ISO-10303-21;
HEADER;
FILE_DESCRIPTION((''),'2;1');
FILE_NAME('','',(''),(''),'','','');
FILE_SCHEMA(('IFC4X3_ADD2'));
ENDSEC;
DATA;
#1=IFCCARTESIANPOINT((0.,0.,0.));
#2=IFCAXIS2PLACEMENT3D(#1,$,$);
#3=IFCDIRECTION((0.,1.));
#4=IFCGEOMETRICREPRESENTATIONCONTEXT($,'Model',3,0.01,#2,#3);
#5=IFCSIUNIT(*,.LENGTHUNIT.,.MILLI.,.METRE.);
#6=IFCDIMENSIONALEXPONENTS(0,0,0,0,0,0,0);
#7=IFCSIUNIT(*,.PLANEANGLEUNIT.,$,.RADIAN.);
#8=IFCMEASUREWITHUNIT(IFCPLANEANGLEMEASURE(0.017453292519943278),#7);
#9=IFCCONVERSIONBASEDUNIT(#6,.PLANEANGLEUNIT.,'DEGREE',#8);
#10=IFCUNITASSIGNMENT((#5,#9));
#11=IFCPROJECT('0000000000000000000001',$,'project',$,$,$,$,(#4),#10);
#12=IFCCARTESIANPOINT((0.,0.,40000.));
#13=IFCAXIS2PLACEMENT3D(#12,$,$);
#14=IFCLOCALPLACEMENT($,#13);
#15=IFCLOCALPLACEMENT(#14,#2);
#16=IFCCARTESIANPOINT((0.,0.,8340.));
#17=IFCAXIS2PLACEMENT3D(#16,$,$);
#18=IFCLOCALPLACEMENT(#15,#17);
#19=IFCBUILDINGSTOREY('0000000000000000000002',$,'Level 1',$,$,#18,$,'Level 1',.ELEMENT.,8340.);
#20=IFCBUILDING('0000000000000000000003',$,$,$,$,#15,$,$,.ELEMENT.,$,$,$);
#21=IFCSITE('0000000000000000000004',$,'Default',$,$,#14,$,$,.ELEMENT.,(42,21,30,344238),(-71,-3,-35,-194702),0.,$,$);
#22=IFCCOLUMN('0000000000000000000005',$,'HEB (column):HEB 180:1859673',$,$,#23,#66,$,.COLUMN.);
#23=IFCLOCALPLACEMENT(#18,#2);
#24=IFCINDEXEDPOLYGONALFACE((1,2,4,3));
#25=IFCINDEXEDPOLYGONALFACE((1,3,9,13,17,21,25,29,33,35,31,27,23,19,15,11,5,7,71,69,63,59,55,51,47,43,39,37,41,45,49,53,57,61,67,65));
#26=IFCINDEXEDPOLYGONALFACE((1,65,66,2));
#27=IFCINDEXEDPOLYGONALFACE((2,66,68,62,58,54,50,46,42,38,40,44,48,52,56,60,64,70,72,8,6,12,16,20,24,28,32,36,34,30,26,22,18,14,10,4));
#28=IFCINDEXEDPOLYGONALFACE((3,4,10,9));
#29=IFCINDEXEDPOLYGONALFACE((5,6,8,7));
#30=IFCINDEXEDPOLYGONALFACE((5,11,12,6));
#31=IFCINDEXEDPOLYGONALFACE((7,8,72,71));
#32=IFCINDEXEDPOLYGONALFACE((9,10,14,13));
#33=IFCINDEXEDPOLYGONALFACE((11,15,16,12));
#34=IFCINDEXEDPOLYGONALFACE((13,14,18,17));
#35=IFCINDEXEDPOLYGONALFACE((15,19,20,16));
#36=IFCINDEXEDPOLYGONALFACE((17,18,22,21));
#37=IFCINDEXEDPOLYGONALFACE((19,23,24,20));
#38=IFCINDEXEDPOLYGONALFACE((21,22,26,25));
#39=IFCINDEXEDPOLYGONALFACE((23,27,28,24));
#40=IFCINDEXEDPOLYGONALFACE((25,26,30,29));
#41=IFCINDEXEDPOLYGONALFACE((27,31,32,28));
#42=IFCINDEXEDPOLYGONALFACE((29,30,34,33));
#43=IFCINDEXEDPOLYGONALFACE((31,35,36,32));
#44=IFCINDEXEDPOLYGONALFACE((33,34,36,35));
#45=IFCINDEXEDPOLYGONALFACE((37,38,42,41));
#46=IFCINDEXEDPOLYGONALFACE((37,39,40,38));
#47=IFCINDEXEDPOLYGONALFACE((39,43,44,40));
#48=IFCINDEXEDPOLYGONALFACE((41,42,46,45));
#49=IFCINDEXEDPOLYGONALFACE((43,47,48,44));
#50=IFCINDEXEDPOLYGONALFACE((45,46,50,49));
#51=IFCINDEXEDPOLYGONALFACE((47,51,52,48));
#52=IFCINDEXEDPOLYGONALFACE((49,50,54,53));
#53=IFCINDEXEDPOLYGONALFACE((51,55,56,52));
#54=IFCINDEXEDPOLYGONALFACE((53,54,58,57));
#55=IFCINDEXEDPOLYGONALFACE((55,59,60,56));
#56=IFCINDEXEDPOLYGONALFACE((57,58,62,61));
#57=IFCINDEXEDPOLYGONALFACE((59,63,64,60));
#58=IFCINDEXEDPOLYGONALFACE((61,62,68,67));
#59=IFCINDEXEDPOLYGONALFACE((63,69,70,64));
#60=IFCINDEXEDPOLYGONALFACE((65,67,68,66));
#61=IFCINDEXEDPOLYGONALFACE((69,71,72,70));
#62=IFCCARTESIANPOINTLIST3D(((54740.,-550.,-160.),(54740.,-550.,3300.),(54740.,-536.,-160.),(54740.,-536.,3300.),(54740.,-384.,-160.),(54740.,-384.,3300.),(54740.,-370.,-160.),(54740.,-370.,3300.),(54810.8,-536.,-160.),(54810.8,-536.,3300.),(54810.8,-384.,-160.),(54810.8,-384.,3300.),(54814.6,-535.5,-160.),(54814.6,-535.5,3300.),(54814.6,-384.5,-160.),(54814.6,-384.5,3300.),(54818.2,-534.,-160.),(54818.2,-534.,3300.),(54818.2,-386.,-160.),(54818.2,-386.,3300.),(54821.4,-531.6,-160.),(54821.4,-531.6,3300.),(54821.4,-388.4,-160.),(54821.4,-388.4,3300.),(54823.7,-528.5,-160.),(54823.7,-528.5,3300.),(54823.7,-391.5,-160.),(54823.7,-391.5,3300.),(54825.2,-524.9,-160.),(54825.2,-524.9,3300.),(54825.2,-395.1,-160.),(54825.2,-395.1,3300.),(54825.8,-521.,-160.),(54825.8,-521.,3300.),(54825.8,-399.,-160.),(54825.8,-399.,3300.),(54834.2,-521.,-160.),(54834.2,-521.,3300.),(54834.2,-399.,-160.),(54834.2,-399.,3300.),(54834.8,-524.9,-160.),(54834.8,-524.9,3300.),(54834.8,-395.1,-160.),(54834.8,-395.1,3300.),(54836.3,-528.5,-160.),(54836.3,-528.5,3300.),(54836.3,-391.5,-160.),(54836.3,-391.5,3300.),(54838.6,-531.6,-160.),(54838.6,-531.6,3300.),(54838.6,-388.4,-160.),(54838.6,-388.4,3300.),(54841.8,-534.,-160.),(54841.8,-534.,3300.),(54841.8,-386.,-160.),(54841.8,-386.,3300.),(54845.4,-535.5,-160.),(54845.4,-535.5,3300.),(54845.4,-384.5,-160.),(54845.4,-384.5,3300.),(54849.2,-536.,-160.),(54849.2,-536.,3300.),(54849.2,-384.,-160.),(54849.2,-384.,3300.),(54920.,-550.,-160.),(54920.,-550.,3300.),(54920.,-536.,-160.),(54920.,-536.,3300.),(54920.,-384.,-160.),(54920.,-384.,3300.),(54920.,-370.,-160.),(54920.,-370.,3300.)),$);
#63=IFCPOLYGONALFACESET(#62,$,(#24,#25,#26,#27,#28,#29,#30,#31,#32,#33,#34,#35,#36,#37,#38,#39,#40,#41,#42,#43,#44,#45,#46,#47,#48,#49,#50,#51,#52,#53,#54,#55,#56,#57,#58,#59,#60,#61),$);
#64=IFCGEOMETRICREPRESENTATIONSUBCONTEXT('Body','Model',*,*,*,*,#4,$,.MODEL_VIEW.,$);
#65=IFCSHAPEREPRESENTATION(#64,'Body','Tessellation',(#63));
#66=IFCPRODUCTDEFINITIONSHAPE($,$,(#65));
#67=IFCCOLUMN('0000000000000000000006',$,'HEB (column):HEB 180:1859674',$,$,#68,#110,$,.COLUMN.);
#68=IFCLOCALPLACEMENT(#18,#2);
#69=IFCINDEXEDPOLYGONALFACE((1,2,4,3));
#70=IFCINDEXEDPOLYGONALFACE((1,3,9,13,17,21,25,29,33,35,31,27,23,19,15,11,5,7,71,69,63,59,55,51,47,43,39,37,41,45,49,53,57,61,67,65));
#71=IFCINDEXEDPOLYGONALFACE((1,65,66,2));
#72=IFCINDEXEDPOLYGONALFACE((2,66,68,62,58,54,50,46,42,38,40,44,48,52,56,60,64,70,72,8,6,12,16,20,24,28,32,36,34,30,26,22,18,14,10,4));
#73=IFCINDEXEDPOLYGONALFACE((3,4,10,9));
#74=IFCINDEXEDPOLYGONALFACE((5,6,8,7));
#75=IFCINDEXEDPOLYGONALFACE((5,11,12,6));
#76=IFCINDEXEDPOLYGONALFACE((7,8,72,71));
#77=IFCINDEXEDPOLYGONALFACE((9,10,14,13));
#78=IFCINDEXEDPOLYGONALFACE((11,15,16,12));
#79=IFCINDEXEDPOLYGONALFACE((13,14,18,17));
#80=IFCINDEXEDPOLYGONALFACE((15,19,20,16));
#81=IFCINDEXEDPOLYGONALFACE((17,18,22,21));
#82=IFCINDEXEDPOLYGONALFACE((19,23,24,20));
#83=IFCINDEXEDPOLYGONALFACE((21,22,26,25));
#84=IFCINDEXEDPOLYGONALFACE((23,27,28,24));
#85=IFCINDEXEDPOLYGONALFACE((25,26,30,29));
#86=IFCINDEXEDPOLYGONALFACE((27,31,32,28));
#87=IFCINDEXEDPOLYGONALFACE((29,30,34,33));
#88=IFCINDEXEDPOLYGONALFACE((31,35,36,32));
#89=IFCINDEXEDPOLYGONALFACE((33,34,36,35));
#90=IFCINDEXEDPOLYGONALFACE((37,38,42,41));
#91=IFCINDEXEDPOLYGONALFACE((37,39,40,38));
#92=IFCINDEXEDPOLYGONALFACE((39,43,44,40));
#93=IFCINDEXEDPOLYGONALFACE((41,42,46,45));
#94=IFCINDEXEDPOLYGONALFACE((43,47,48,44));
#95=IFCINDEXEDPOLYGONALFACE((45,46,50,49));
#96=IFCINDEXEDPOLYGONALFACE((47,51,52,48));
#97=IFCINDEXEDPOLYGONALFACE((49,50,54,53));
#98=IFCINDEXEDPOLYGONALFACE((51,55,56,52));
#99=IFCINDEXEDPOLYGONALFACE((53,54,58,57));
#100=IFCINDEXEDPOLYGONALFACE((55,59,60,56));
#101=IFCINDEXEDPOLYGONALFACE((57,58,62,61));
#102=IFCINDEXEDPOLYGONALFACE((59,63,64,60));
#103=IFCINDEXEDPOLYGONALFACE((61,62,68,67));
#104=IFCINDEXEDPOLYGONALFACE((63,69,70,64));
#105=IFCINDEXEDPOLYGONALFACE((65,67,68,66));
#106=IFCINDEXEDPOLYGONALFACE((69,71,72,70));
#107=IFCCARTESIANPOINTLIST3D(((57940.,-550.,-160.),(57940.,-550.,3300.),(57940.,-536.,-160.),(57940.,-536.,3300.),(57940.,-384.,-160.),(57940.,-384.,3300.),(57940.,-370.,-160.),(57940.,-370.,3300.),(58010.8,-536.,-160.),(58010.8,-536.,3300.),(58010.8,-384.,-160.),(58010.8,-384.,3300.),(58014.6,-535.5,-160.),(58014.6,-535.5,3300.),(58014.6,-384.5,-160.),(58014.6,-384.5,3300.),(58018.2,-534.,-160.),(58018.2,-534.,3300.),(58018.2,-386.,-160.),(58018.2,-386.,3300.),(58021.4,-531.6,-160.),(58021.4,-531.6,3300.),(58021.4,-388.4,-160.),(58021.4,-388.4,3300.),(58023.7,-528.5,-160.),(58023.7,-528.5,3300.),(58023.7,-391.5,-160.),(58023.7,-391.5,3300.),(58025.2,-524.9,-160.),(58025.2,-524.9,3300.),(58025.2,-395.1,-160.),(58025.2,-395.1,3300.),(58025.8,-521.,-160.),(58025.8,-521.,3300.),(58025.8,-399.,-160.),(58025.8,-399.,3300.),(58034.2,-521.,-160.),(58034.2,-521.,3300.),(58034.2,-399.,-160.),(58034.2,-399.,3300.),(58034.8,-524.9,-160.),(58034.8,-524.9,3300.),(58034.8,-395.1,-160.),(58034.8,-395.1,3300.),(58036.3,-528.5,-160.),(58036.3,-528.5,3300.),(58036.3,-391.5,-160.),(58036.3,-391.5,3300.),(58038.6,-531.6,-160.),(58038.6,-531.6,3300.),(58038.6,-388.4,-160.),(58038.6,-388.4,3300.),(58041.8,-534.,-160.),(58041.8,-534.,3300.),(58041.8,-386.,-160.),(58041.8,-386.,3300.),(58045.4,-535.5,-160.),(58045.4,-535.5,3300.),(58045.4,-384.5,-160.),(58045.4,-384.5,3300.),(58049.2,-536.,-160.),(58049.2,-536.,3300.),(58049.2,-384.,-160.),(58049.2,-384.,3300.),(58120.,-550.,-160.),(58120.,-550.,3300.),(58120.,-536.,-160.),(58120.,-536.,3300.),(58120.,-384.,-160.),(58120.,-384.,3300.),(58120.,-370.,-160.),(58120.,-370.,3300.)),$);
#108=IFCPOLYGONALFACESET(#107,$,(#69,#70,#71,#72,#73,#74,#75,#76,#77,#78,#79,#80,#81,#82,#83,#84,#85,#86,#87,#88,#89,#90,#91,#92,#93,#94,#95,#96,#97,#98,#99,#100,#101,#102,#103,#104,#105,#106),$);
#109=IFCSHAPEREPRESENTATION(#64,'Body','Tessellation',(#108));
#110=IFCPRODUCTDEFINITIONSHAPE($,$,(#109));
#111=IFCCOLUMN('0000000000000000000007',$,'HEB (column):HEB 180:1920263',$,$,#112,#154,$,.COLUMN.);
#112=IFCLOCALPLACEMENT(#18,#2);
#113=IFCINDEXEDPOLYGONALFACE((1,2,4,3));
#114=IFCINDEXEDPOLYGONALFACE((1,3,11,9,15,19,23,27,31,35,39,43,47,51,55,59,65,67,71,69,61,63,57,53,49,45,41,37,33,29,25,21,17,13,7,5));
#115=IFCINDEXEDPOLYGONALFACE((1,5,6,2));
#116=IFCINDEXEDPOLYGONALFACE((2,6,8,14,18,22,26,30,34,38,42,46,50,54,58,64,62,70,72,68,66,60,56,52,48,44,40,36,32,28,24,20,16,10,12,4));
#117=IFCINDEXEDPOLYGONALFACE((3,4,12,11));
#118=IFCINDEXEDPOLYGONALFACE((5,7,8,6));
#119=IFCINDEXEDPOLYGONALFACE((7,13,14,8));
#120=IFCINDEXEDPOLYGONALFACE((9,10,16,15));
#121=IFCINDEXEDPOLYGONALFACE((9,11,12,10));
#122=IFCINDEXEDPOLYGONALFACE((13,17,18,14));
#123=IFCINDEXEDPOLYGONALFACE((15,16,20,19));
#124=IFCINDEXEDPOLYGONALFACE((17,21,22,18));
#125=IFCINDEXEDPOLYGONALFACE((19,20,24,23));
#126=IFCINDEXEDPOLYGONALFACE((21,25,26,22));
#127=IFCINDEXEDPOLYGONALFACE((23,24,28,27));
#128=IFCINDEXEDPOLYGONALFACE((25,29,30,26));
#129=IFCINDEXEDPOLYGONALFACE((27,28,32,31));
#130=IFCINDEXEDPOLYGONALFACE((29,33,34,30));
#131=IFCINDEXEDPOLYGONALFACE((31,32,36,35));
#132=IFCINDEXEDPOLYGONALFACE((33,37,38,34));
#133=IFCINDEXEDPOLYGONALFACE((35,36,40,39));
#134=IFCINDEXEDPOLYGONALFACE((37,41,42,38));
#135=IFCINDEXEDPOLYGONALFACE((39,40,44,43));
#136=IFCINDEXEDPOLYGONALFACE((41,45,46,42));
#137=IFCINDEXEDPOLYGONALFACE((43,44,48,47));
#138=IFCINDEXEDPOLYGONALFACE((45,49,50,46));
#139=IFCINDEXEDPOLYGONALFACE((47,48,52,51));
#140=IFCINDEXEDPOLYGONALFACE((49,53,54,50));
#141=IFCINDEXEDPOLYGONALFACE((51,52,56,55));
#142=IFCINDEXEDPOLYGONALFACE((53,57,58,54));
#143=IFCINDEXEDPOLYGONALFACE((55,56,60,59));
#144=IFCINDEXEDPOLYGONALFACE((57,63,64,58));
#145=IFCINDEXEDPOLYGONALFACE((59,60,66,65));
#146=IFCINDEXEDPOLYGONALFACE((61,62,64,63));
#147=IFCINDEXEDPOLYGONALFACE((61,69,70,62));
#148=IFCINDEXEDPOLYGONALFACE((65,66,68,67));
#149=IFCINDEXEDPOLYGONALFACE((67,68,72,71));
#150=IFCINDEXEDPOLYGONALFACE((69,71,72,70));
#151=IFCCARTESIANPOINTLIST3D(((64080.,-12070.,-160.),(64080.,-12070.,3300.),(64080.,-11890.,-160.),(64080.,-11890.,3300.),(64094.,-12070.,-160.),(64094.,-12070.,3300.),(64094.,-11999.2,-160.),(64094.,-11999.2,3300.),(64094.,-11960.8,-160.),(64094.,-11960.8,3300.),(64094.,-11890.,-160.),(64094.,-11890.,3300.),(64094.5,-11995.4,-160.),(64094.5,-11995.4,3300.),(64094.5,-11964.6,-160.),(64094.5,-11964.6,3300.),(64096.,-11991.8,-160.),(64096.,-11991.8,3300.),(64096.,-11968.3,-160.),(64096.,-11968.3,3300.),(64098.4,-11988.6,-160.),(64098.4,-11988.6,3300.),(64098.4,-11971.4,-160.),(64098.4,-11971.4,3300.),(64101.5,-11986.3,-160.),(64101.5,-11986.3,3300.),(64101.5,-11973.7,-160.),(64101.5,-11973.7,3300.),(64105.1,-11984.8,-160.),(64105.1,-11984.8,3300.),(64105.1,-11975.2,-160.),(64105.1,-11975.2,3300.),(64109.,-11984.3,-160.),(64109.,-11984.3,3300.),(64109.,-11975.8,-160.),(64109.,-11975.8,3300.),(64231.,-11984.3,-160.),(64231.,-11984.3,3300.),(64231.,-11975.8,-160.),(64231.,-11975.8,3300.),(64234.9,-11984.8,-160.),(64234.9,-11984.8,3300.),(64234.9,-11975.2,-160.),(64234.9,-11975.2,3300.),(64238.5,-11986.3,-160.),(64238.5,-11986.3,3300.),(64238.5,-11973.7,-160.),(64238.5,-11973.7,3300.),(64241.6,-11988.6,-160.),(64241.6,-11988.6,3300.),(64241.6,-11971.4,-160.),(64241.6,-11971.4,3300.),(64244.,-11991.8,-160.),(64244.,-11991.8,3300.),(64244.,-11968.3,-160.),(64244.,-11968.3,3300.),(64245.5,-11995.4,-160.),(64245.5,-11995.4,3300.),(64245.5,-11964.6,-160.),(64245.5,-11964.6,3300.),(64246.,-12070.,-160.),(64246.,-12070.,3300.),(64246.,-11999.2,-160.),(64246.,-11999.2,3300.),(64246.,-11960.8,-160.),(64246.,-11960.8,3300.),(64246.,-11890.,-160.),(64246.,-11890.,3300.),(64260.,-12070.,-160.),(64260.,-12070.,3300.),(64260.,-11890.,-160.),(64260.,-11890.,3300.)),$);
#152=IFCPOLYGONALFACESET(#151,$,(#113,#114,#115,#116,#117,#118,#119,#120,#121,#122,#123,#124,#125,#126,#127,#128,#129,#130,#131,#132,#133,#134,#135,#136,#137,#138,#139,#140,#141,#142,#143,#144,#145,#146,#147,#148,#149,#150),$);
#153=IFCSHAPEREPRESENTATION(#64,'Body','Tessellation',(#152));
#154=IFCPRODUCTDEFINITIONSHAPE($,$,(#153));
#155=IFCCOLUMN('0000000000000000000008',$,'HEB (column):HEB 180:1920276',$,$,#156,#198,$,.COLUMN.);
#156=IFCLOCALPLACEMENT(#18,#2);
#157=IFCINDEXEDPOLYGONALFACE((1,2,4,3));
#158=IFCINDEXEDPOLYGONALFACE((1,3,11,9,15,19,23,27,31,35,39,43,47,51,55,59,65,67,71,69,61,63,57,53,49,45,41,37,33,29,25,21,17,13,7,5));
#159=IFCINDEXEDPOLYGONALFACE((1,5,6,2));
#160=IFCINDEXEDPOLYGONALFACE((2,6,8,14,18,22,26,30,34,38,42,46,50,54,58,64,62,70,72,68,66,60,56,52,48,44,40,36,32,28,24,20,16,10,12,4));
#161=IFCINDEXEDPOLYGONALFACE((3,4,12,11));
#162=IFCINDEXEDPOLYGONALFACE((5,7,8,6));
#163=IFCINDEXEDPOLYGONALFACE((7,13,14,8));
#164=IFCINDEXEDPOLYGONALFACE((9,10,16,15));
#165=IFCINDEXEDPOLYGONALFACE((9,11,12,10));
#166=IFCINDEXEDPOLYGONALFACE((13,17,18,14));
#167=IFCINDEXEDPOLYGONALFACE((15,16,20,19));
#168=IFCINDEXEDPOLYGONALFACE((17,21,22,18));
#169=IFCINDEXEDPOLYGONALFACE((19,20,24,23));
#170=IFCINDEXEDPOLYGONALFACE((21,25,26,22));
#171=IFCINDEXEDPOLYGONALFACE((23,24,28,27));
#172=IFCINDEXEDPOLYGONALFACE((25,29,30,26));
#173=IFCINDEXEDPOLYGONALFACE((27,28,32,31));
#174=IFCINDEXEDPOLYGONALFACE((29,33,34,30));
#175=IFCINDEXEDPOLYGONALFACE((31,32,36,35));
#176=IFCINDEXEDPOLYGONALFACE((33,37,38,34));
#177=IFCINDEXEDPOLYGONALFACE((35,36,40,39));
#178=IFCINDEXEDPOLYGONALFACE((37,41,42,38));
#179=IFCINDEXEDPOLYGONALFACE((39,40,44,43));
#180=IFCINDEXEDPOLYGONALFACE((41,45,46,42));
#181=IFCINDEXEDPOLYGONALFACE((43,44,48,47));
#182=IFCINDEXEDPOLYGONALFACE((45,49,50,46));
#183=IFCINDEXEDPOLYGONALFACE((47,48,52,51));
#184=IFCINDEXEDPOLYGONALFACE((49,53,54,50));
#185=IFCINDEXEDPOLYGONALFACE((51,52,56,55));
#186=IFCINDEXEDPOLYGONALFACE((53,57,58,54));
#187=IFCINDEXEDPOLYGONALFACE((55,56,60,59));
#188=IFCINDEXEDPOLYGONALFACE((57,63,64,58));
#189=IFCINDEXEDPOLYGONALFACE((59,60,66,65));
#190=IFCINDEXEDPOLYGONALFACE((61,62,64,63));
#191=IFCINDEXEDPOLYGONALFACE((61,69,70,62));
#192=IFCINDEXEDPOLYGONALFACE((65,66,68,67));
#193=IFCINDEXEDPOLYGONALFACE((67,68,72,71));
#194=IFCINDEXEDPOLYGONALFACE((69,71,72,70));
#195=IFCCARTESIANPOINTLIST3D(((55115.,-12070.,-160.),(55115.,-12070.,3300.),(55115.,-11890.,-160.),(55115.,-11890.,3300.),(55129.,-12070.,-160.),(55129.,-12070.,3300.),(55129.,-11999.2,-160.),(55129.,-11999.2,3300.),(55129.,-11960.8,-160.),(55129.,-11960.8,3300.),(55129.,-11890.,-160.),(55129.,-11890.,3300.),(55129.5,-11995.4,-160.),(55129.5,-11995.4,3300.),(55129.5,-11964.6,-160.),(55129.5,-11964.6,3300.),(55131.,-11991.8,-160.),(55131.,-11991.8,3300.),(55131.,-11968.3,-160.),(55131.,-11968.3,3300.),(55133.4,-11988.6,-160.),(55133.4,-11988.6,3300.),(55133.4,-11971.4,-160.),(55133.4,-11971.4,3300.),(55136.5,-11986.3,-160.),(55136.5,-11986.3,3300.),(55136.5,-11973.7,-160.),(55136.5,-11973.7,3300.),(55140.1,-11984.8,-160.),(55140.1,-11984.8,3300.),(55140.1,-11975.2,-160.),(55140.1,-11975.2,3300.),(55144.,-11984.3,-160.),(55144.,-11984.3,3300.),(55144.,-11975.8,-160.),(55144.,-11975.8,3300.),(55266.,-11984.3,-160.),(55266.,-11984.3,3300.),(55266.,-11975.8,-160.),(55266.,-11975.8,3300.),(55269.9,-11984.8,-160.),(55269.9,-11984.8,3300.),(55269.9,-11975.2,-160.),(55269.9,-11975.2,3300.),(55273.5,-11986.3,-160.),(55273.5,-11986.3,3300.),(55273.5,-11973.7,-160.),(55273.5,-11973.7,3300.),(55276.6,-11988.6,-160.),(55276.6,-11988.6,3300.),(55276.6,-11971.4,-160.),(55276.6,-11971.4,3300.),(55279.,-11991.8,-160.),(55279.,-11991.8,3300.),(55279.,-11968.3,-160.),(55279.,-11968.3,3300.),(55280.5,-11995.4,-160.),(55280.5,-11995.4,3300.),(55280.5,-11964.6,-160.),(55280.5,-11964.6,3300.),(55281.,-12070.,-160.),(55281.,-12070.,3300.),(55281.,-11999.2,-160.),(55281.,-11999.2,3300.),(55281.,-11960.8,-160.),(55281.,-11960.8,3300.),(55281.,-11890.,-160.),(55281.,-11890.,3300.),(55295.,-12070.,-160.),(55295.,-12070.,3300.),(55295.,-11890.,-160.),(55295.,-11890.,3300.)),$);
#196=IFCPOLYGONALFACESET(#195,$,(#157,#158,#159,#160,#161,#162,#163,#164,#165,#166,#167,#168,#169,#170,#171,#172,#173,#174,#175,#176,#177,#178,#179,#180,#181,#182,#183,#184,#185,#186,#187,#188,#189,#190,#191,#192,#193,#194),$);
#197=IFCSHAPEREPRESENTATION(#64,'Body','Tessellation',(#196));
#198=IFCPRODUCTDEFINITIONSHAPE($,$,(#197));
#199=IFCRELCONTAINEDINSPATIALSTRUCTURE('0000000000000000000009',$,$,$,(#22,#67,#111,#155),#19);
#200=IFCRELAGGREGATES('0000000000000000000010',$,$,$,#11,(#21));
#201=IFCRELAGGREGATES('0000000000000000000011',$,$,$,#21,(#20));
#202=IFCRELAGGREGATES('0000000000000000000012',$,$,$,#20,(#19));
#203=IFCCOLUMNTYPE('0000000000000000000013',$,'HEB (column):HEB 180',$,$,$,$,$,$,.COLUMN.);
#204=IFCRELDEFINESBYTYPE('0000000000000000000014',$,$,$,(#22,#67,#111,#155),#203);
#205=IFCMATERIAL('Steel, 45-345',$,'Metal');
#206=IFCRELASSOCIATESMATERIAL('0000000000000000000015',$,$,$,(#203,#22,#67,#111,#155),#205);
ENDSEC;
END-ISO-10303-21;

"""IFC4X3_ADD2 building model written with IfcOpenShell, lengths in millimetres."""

from ifc_helpers import new_model, entity, si_unit, converted_unit, direction, frame, origin, origin_2d_with_axis, place, context, subcontext, project, spatial, i_section, extrude, source, transform, mapped, material, material_profile, profile_set, profile_usage, type_object, type_shapes, element, save


model = new_model("IFC4X3_ADD2")

# Units and contexts
model_context = context("Model", 3, precision=0.01, world=origin(), true_north=direction((0.0, 1.0)))
body_context = subcontext(model_context, "Body", "Model", "MODEL_VIEW")
ifc_project = project(units=[si_unit("LENGTHUNIT", "METRE", prefix="MILLI"), converted_unit("PLANEANGLEUNIT", "DEGREE", entity("IfcPlaneAngleMeasure", 0.017453292519943278), si_unit("PLANEANGLEUNIT", "RADIAN"), dimensions=[0, 0, 0, 0, 0, 0, 0])], contexts=[model_context])

# Site, building, storey
site_placement = place(None, frame((0.0, 0.0, 40000.0)))
site = spatial("IfcSite", under=ifc_project, at=site_placement, Name="Default", CompositionType="ELEMENT", RefLatitude=(42, 21, 30, 344238), RefLongitude=(-71, -3, -35, -194702), RefElevation=0.0)
building_placement = place(site_placement, origin())
building = spatial("IfcBuilding", under=site, at=building_placement, CompositionType="ELEMENT")
storey_placement = place(building_placement, frame((0.0, 0.0, 8340.0)))
storey = spatial("IfcBuildingStorey", under=building, at=storey_placement, Name="Level 1", LongName="Level 1", CompositionType="ELEMENT", Elevation=8340.0)

# Columns
ifc_material = material(Name="Steel, 45-345", Category="Metal")
ifc_material_profile_1 = material_profile(ifc_material, i_section(OverallWidth=180.0, OverallDepth=180.0, WebThickness=8.5, FlangeThickness=14.0, FilletRadius=15.0, at=origin_2d_with_axis()), Name="HEB 180")
ifc_profile_set_1 = profile_set([ifc_material_profile_1], Name="HEB 180")
ifc_profile_usage_1 = profile_usage(ifc_profile_set_1)
column_type_1 = type_object("IfcColumnType", Name="HEB (column):HEB 180", PredefinedType="COLUMN", material=ifc_profile_set_1)
shared_shape_1 = source(origin(), body_context, "Body", "SweptSolid", [
    extrude(i_section(OverallWidth=180.0, OverallDepth=180.0, WebThickness=8.5, FlangeThickness=14.0, FilletRadius=15.0, at=origin_2d_with_axis()), frame((0.0, 0.0, 8180.0), z_axis=(0.0, 0.0, 1.0), x_axis=(-1.0, 0.0, 0.0)), (0.0, 0.0, 1.0), 3460.0),
])
type_shapes(column_type_1, [shared_shape_1])
for number, where, name in (
    (1, (54830.0, -460.0, -8340.0), "HEB (column):HEB 180:1859673"),
    (2, (58030.0, -460.0, -8340.0), "HEB (column):HEB 180:1859674"),
):
    element("IfcColumn", number, at=place(storey_placement, frame(where)), inside=storey, type_object=column_type_1, material=ifc_profile_usage_1, Name=name, PredefinedType="COLUMN", context=body_context, shape_type="MappedRepresentation", body=[
        mapped(shared_shape_1, transform((0.0, 0.0, 0.0), scale=1.0)),
    ])
for number, where, z_axis, x_axis, name in (
    (3, (64170.0, -11980.0, -8340.0), (0.0, 0.0, 1.0), (0.0, -1.0, 0.0), "HEB (column):HEB 180:1920263"),
    (4, (55205.0, -11980.0, -8340.0), (0.0, 0.0, 1.0), (0.0, -1.0, 0.0), "HEB (column):HEB 180:1920276"),
):
    element("IfcColumn", number, at=place(storey_placement, frame(where, z_axis=z_axis, x_axis=x_axis)), inside=storey, type_object=column_type_1, material=ifc_profile_usage_1, Name=name, PredefinedType="COLUMN", context=body_context, shape_type="MappedRepresentation", body=[
        mapped(shared_shape_1, transform((0.0, 0.0, 0.0), scale=1.0)),
    ])

save(model, "model.ifc")
